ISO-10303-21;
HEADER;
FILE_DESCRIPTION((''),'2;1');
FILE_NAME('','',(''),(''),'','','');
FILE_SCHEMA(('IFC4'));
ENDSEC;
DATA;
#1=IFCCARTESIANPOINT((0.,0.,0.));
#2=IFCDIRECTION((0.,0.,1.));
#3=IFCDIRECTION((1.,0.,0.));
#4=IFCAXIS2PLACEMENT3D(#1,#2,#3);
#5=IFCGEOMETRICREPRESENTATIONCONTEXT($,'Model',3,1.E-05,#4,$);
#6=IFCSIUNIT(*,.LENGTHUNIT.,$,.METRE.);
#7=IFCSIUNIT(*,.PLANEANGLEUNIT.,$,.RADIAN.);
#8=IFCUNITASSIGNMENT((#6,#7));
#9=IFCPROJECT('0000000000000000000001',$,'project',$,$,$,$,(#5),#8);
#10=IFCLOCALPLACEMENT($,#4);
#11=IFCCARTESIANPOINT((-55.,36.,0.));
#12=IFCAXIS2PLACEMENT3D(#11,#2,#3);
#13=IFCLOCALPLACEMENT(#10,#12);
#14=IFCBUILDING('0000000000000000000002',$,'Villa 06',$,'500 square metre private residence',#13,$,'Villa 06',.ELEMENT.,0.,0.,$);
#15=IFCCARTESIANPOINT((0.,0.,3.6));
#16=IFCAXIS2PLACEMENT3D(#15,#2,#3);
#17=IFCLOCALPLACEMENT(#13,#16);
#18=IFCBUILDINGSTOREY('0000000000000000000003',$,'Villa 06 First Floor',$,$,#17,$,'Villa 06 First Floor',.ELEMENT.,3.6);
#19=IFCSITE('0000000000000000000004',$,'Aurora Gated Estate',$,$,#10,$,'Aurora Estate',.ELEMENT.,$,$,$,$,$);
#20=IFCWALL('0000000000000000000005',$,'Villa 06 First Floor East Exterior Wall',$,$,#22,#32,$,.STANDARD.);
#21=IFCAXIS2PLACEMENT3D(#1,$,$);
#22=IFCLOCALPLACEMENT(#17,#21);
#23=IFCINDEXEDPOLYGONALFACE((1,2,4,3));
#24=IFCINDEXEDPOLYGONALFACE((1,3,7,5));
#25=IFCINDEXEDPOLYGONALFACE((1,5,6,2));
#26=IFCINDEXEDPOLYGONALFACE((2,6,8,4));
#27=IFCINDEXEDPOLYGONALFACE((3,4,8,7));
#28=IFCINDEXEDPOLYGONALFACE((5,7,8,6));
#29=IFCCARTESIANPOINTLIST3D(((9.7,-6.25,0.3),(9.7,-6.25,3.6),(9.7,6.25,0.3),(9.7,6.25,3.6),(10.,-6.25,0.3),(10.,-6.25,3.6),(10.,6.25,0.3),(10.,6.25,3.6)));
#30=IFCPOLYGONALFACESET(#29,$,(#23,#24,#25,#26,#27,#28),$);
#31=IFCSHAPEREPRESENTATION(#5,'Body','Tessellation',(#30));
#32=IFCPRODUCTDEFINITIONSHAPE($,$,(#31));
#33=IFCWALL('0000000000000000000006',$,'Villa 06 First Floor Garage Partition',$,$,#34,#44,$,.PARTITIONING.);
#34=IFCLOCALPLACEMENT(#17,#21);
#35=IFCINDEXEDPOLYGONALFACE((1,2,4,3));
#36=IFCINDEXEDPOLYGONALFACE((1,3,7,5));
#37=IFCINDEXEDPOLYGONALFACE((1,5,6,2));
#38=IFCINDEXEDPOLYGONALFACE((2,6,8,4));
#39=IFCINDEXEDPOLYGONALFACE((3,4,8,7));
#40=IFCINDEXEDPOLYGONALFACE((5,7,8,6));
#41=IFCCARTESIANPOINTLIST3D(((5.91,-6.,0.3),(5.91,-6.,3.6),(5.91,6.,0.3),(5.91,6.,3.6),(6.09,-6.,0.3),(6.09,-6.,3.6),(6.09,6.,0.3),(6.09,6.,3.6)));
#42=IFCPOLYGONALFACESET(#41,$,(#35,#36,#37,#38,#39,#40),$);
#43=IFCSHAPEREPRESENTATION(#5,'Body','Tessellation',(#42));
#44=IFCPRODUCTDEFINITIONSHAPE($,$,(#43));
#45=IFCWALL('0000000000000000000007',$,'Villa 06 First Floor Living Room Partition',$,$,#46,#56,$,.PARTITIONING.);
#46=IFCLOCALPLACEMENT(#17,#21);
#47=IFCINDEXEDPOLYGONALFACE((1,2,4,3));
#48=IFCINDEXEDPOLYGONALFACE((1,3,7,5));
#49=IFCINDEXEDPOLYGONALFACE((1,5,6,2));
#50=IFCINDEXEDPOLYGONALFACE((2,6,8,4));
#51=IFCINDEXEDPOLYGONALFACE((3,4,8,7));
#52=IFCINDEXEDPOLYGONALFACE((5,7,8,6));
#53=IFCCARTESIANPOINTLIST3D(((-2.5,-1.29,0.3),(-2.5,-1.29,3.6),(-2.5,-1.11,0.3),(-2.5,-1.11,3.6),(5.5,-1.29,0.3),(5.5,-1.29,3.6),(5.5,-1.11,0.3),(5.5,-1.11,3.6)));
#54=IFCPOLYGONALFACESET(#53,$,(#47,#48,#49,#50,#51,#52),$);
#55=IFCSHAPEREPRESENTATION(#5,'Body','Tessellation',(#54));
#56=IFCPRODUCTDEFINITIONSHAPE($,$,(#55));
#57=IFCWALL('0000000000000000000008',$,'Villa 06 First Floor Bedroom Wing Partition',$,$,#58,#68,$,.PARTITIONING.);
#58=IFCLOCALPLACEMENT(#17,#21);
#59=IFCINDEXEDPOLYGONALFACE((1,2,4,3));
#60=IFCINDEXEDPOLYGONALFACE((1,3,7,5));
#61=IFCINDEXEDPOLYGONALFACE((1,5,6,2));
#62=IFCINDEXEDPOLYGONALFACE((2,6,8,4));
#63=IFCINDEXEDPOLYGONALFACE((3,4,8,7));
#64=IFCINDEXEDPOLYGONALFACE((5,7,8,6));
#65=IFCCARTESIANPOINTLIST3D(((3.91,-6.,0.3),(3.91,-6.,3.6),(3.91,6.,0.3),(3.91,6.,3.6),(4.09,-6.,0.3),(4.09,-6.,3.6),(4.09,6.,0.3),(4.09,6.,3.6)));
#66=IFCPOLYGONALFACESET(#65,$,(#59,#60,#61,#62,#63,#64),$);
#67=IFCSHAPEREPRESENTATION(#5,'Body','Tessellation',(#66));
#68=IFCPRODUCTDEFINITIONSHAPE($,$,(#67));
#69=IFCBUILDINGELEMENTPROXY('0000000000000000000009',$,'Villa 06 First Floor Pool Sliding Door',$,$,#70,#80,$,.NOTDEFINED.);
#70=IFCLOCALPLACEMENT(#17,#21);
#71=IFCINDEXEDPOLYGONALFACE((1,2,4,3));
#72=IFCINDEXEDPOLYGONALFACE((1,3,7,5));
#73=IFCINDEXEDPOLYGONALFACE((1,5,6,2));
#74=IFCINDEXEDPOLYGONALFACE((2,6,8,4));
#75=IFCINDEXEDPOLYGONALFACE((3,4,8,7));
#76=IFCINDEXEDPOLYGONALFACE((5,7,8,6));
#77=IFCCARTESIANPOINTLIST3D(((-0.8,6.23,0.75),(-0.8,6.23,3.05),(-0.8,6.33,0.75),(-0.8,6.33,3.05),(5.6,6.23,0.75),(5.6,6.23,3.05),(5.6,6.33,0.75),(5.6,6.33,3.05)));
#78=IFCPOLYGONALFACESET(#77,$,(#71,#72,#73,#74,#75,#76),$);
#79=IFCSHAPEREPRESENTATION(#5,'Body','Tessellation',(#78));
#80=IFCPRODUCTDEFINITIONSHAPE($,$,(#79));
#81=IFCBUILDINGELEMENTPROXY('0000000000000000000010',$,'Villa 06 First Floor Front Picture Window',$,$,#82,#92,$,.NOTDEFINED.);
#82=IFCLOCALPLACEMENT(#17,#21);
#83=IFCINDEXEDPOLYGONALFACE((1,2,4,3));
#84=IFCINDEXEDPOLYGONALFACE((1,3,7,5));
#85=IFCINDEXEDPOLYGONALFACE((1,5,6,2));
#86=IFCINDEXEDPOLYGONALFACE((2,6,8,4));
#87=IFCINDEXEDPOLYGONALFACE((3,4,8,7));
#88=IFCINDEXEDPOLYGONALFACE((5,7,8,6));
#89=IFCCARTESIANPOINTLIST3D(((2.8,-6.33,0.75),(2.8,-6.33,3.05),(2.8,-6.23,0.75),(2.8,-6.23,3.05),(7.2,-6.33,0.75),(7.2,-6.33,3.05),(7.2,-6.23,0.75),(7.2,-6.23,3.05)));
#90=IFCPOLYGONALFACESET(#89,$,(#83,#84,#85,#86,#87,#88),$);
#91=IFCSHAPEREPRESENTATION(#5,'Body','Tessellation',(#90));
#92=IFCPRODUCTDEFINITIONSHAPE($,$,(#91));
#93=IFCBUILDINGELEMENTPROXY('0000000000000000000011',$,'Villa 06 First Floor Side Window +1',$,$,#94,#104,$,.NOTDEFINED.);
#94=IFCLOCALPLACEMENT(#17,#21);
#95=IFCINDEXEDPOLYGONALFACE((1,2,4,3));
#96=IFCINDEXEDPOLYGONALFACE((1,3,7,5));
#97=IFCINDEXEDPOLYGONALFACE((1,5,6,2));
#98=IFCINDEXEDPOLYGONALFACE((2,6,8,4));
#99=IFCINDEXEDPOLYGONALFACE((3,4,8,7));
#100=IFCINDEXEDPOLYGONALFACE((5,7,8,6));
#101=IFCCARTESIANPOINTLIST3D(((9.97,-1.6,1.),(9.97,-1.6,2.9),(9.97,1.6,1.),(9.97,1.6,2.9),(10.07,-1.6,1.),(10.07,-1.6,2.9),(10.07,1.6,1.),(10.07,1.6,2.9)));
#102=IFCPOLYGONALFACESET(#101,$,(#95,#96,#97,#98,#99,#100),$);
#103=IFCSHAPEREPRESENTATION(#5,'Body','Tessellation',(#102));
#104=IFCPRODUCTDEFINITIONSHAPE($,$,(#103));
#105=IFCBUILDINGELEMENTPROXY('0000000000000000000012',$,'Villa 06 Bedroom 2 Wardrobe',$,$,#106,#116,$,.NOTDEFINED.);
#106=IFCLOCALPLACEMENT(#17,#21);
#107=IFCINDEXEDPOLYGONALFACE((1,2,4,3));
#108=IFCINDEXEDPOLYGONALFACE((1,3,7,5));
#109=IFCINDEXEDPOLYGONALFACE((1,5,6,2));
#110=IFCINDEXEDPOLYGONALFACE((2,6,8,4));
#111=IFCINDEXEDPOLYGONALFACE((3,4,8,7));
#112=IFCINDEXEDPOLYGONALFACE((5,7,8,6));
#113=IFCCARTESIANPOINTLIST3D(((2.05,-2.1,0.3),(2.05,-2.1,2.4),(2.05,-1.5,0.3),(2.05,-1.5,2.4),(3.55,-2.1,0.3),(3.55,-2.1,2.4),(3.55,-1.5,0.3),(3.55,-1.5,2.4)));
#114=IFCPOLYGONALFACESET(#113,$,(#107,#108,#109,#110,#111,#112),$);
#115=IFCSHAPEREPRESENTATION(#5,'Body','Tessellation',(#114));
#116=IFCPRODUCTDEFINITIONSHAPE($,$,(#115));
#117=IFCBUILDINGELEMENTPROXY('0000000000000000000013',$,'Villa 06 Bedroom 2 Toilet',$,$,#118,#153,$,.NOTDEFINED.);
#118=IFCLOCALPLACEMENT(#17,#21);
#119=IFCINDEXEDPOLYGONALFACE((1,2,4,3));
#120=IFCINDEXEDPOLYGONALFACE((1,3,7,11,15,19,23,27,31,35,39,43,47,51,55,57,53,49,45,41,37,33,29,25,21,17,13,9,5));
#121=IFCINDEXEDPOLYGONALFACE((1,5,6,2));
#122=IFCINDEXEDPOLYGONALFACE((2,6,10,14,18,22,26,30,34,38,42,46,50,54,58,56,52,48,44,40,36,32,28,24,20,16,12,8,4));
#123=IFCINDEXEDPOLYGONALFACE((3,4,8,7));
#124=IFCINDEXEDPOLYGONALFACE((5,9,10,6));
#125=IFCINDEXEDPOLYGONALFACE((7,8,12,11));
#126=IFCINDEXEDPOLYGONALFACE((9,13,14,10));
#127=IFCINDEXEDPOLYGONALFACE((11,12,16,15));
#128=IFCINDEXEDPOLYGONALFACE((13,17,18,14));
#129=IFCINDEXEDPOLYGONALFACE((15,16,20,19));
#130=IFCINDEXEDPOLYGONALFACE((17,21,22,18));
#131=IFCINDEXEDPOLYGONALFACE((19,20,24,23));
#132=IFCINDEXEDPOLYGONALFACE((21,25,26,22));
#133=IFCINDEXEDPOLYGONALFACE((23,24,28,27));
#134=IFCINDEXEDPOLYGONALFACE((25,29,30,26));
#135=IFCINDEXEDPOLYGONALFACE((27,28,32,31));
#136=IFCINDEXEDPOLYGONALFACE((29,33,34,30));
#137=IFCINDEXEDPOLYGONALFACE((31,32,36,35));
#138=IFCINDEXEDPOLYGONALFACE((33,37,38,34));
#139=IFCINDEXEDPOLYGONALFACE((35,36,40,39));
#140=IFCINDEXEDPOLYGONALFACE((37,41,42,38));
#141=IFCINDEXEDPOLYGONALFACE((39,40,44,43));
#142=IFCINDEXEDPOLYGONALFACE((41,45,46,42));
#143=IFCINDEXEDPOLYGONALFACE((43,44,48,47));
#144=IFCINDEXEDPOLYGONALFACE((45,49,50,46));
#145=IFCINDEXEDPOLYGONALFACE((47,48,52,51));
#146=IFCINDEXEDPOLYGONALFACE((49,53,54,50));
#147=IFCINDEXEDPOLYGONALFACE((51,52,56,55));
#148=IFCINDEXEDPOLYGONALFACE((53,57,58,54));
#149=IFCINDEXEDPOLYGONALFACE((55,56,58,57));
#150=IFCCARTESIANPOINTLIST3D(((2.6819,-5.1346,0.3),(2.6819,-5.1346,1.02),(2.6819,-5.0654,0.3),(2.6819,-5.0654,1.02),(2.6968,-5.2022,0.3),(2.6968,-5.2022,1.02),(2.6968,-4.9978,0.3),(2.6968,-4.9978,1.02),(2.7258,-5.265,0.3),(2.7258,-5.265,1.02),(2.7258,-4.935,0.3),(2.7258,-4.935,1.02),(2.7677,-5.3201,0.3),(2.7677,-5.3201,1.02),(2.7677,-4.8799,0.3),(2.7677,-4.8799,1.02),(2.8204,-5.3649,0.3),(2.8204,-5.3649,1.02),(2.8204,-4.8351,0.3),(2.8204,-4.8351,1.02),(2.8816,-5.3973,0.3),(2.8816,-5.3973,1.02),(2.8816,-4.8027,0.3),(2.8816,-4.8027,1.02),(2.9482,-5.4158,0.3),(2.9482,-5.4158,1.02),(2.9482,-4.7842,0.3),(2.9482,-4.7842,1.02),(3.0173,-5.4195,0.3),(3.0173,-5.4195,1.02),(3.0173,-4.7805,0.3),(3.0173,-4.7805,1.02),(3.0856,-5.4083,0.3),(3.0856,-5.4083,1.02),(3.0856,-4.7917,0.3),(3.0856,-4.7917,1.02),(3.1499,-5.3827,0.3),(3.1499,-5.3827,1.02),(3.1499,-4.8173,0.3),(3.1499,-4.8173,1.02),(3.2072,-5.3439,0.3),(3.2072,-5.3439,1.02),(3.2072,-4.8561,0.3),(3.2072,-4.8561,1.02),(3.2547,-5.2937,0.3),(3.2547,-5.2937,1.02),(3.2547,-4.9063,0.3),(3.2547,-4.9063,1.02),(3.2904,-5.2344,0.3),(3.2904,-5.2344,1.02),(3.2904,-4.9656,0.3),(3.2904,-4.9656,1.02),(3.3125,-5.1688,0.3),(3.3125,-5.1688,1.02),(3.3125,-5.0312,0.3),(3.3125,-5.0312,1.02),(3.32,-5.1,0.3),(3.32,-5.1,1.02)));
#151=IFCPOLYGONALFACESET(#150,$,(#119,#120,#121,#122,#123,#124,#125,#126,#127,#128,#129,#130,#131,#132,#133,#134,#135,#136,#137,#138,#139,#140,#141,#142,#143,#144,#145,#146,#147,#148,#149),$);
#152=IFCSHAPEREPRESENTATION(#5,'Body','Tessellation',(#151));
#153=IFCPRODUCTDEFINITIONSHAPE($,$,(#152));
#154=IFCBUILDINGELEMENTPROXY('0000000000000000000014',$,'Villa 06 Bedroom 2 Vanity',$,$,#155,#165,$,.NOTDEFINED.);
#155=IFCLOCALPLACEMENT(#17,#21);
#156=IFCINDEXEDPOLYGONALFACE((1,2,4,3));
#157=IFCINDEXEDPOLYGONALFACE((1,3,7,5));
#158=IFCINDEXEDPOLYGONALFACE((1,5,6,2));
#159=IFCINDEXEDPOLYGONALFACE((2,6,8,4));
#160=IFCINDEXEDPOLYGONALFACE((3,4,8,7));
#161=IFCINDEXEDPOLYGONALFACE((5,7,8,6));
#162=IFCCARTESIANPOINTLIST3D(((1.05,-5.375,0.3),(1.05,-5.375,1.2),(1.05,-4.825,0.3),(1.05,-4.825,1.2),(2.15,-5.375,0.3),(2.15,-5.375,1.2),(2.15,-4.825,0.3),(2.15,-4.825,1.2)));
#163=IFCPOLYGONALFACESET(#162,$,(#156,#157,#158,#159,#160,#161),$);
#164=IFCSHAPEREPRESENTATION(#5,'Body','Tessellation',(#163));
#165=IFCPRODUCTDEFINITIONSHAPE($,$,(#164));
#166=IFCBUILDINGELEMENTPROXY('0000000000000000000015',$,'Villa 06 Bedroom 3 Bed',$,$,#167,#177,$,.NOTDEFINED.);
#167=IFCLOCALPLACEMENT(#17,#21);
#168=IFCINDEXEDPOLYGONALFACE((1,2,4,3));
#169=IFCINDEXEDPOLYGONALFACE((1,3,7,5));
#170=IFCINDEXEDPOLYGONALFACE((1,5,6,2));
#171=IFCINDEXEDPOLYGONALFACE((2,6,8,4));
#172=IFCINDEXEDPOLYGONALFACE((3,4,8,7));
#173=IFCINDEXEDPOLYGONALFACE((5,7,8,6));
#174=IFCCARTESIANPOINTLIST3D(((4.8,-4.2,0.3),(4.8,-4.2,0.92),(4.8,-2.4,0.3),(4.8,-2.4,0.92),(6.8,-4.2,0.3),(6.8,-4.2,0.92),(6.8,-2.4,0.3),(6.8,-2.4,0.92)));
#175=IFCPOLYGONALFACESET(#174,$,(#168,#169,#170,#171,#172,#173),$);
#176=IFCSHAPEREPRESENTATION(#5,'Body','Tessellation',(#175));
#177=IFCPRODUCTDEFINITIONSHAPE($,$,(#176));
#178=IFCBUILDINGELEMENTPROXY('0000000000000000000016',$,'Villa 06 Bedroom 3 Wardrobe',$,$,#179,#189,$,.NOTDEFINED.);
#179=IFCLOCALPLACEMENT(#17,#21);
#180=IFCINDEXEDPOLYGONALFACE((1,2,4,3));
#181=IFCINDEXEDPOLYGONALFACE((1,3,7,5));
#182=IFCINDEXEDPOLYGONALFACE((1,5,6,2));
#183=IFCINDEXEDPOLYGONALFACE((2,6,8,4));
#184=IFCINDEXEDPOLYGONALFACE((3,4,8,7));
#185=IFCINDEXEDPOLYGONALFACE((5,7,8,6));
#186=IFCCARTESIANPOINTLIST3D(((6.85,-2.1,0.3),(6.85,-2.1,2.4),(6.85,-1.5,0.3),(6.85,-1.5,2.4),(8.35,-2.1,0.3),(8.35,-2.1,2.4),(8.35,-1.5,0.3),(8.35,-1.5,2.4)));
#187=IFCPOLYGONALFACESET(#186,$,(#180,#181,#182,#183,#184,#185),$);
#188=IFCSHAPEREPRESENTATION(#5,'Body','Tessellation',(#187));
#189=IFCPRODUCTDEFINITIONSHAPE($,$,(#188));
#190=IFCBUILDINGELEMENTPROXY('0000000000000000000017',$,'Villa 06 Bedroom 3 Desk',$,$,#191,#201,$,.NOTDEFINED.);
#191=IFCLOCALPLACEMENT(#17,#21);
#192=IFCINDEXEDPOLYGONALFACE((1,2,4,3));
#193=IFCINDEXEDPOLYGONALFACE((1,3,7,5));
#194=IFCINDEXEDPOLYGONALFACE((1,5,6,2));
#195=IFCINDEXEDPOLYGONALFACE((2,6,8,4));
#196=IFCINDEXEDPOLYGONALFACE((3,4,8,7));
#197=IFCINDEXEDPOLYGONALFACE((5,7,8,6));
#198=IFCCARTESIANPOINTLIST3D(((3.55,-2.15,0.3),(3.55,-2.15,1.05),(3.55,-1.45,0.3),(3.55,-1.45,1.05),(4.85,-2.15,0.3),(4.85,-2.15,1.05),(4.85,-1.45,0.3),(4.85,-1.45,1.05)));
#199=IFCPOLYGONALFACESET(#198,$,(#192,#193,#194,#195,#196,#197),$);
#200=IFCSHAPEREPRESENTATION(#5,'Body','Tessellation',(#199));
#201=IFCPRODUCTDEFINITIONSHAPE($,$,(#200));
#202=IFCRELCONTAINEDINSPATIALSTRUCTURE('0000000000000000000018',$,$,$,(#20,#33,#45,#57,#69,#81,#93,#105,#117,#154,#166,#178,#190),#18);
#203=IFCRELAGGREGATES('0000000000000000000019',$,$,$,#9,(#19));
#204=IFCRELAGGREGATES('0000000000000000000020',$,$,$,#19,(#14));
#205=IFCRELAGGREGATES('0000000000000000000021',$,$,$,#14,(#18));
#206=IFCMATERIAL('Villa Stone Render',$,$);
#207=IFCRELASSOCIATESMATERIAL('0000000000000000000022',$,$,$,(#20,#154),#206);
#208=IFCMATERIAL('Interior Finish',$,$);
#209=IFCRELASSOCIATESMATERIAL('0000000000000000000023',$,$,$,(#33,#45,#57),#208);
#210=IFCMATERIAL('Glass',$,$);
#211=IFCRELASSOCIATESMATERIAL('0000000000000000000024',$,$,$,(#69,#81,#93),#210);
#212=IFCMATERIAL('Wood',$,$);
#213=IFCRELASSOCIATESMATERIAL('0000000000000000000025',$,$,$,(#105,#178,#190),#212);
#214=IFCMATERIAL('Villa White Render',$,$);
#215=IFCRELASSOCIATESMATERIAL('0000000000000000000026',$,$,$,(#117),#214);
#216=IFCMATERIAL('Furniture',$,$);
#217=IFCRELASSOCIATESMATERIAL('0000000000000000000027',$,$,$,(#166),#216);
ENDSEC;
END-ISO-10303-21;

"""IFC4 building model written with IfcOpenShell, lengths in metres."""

from ifc_helpers import new_model, si_unit, frame, origin_with_axes, origin_2d_with_axis, place, context, project, spatial, rectangle, circle, extrude, material, element, save


model = new_model("IFC4")

# Units and contexts
model_context = context("Model", 3, precision=1e-05, world=origin_with_axes())
ifc_project = project(units=[si_unit("LENGTHUNIT", "METRE"), si_unit("PLANEANGLEUNIT", "RADIAN")], contexts=[model_context])

# Site, building, storey
site_placement = place(None, origin_with_axes())
site = spatial("IfcSite", under=ifc_project, at=site_placement, Name="Aurora Gated Estate", LongName="Aurora Estate", CompositionType="ELEMENT")
building_placement = place(site_placement, frame((-55.0, 36.0, 0.0), z_axis=(0.0, 0.0, 1.0), x_axis=(1.0, 0.0, 0.0)))
building = spatial("IfcBuilding", under=site, at=building_placement, Name="Villa 06", ObjectType="500 square metre private residence", LongName="Villa 06", CompositionType="ELEMENT", ElevationOfRefHeight=0.0, ElevationOfTerrain=0.0)
storey_placement = place(building_placement, frame((0.0, 0.0, 3.6), z_axis=(0.0, 0.0, 1.0), x_axis=(1.0, 0.0, 0.0)))
storey = spatial("IfcBuildingStorey", under=building, at=storey_placement, Name="Villa 06 First Floor", LongName="Villa 06 First Floor", CompositionType="ELEMENT", Elevation=3.6)

# Walls
ifc_material_1 = material(Name="Villa Stone Render")
wall_1_placement = place(storey_placement, frame((9.85, 0.0, 0.3), z_axis=(0.0, 0.0, 1.0), x_axis=(1.0, 0.0, 0.0)))
element("IfcWall", 1, at=wall_1_placement, inside=storey, material=ifc_material_1, Name="Villa 06 First Floor East Exterior Wall", PredefinedType="STANDARD", context=model_context, shape_type="SweptSolid", body=[
    extrude(rectangle(XDim=0.3, YDim=12.5, at=origin_2d_with_axis()), origin_with_axes(), (0.0, 0.0, 1.0), 3.3),
])
ifc_material_2 = material(Name="Interior Finish")
wall_2_placement = place(storey_placement, frame((6.0, 0.0, 0.3), z_axis=(0.0, 0.0, 1.0), x_axis=(1.0, 0.0, 0.0)))
element("IfcWall", 2, at=wall_2_placement, inside=storey, material=ifc_material_2, Name="Villa 06 First Floor Garage Partition", PredefinedType="PARTITIONING", context=model_context, shape_type="SweptSolid", body=[
    extrude(rectangle(XDim=0.18, YDim=12.0, at=origin_2d_with_axis()), origin_with_axes(), (0.0, 0.0, 1.0), 3.3),
])
wall_3_placement = place(storey_placement, frame((1.5, -1.2, 0.3), z_axis=(0.0, 0.0, 1.0), x_axis=(1.0, 0.0, 0.0)))
element("IfcWall", 3, at=wall_3_placement, inside=storey, material=ifc_material_2, Name="Villa 06 First Floor Living Room Partition", PredefinedType="PARTITIONING", context=model_context, shape_type="SweptSolid", body=[
    extrude(rectangle(XDim=8.0, YDim=0.18, at=origin_2d_with_axis()), origin_with_axes(), (0.0, 0.0, 1.0), 3.3),
])
wall_4_placement = place(storey_placement, frame((4.0, 0.0, 0.3), z_axis=(0.0, 0.0, 1.0), x_axis=(1.0, 0.0, 0.0)))
element("IfcWall", 4, at=wall_4_placement, inside=storey, material=ifc_material_2, Name="Villa 06 First Floor Bedroom Wing Partition", PredefinedType="PARTITIONING", context=model_context, shape_type="SweptSolid", body=[
    extrude(rectangle(XDim=0.18, YDim=12.0, at=origin_2d_with_axis()), origin_with_axes(), (0.0, 0.0, 1.0), 3.3),
])

# Building element proxies
ifc_material_3 = material(Name="Glass")
proxy_1_placement = place(storey_placement, frame((2.4, 6.28, 0.75), z_axis=(0.0, 0.0, 1.0), x_axis=(1.0, 0.0, 0.0)))
element("IfcBuildingElementProxy", 5, at=proxy_1_placement, inside=storey, material=ifc_material_3, Name="Villa 06 First Floor Pool Sliding Door", PredefinedType="NOTDEFINED", context=model_context, shape_type="SweptSolid", body=[
    extrude(rectangle(XDim=6.4, YDim=0.1, at=origin_2d_with_axis()), origin_with_axes(), (0.0, 0.0, 1.0), 2.3),
])
proxy_2_placement = place(storey_placement, frame((5.0, -6.28, 0.75), z_axis=(0.0, 0.0, 1.0), x_axis=(1.0, 0.0, 0.0)))
element("IfcBuildingElementProxy", 6, at=proxy_2_placement, inside=storey, material=ifc_material_3, Name="Villa 06 First Floor Front Picture Window", PredefinedType="NOTDEFINED", context=model_context, shape_type="SweptSolid", body=[
    extrude(rectangle(XDim=4.4, YDim=0.1, at=origin_2d_with_axis()), origin_with_axes(), (0.0, 0.0, 1.0), 2.3),
])
proxy_3_placement = place(storey_placement, frame((10.02, 0.0, 1.0), z_axis=(0.0, 0.0, 1.0), x_axis=(0.0, 1.0, 0.0)))
element("IfcBuildingElementProxy", 7, at=proxy_3_placement, inside=storey, material=ifc_material_3, Name="Villa 06 First Floor Side Window +1", PredefinedType="NOTDEFINED", context=model_context, shape_type="SweptSolid", body=[
    extrude(rectangle(XDim=3.2, YDim=0.1, at=origin_2d_with_axis()), origin_with_axes(), (0.0, 0.0, 1.0), 1.9),
])
ifc_material_4 = material(Name="Wood")
proxy_4_placement = place(storey_placement, frame((2.8, -1.8, 0.3), z_axis=(0.0, 0.0, 1.0), x_axis=(1.0, 0.0, 0.0)))
element("IfcBuildingElementProxy", 8, at=proxy_4_placement, inside=storey, material=ifc_material_4, Name="Villa 06 Bedroom 2 Wardrobe", PredefinedType="NOTDEFINED", context=model_context, shape_type="SweptSolid", body=[
    extrude(rectangle(XDim=1.5, YDim=0.6, at=origin_2d_with_axis()), origin_with_axes(), (0.0, 0.0, 1.0), 2.1),
])
ifc_material_5 = material(Name="Villa White Render")
proxy_5_placement = place(storey_placement, frame((3.0, -5.1, 0.3), z_axis=(0.0, 0.0, 1.0), x_axis=(1.0, 0.0, 0.0)))
element("IfcBuildingElementProxy", 9, at=proxy_5_placement, inside=storey, material=ifc_material_5, Name="Villa 06 Bedroom 2 Toilet", PredefinedType="NOTDEFINED", context=model_context, shape_type="SweptSolid", body=[
    extrude(circle(Radius=0.32, at=origin_2d_with_axis()), origin_with_axes(), (0.0, 0.0, 1.0), 0.72),
])
proxy_6_placement = place(storey_placement, frame((1.6, -5.1, 0.3), z_axis=(0.0, 0.0, 1.0), x_axis=(1.0, 0.0, 0.0)))
element("IfcBuildingElementProxy", 10, at=proxy_6_placement, inside=storey, material=ifc_material_1, Name="Villa 06 Bedroom 2 Vanity", PredefinedType="NOTDEFINED", context=model_context, shape_type="SweptSolid", body=[
    extrude(rectangle(XDim=1.1, YDim=0.55, at=origin_2d_with_axis()), origin_with_axes(), (0.0, 0.0, 1.0), 0.9),
])
ifc_material_6 = material(Name="Furniture")
proxy_7_placement = place(storey_placement, frame((5.8, -3.3, 0.3), z_axis=(0.0, 0.0, 1.0), x_axis=(1.0, 0.0, 0.0)))
element("IfcBuildingElementProxy", 11, at=proxy_7_placement, inside=storey, material=ifc_material_6, Name="Villa 06 Bedroom 3 Bed", PredefinedType="NOTDEFINED", context=model_context, shape_type="SweptSolid", body=[
    extrude(rectangle(XDim=2.0, YDim=1.8, at=origin_2d_with_axis()), origin_with_axes(), (0.0, 0.0, 1.0), 0.62),
])
proxy_8_placement = place(storey_placement, frame((7.6, -1.8, 0.3), z_axis=(0.0, 0.0, 1.0), x_axis=(1.0, 0.0, 0.0)))
element("IfcBuildingElementProxy", 12, at=proxy_8_placement, inside=storey, material=ifc_material_4, Name="Villa 06 Bedroom 3 Wardrobe", PredefinedType="NOTDEFINED", context=model_context, shape_type="SweptSolid", body=[
    extrude(rectangle(XDim=1.5, YDim=0.6, at=origin_2d_with_axis()), origin_with_axes(), (0.0, 0.0, 1.0), 2.1),
])
proxy_9_placement = place(storey_placement, frame((4.2, -1.8, 0.3), z_axis=(0.0, 0.0, 1.0), x_axis=(1.0, 0.0, 0.0)))
element("IfcBuildingElementProxy", 13, at=proxy_9_placement, inside=storey, material=ifc_material_4, Name="Villa 06 Bedroom 3 Desk", PredefinedType="NOTDEFINED", context=model_context, shape_type="SweptSolid", body=[
    extrude(rectangle(XDim=1.3, YDim=0.7, at=origin_2d_with_axis()), origin_with_axes(), (0.0, 0.0, 1.0), 0.75),
])

save(model, "model.ifc")
